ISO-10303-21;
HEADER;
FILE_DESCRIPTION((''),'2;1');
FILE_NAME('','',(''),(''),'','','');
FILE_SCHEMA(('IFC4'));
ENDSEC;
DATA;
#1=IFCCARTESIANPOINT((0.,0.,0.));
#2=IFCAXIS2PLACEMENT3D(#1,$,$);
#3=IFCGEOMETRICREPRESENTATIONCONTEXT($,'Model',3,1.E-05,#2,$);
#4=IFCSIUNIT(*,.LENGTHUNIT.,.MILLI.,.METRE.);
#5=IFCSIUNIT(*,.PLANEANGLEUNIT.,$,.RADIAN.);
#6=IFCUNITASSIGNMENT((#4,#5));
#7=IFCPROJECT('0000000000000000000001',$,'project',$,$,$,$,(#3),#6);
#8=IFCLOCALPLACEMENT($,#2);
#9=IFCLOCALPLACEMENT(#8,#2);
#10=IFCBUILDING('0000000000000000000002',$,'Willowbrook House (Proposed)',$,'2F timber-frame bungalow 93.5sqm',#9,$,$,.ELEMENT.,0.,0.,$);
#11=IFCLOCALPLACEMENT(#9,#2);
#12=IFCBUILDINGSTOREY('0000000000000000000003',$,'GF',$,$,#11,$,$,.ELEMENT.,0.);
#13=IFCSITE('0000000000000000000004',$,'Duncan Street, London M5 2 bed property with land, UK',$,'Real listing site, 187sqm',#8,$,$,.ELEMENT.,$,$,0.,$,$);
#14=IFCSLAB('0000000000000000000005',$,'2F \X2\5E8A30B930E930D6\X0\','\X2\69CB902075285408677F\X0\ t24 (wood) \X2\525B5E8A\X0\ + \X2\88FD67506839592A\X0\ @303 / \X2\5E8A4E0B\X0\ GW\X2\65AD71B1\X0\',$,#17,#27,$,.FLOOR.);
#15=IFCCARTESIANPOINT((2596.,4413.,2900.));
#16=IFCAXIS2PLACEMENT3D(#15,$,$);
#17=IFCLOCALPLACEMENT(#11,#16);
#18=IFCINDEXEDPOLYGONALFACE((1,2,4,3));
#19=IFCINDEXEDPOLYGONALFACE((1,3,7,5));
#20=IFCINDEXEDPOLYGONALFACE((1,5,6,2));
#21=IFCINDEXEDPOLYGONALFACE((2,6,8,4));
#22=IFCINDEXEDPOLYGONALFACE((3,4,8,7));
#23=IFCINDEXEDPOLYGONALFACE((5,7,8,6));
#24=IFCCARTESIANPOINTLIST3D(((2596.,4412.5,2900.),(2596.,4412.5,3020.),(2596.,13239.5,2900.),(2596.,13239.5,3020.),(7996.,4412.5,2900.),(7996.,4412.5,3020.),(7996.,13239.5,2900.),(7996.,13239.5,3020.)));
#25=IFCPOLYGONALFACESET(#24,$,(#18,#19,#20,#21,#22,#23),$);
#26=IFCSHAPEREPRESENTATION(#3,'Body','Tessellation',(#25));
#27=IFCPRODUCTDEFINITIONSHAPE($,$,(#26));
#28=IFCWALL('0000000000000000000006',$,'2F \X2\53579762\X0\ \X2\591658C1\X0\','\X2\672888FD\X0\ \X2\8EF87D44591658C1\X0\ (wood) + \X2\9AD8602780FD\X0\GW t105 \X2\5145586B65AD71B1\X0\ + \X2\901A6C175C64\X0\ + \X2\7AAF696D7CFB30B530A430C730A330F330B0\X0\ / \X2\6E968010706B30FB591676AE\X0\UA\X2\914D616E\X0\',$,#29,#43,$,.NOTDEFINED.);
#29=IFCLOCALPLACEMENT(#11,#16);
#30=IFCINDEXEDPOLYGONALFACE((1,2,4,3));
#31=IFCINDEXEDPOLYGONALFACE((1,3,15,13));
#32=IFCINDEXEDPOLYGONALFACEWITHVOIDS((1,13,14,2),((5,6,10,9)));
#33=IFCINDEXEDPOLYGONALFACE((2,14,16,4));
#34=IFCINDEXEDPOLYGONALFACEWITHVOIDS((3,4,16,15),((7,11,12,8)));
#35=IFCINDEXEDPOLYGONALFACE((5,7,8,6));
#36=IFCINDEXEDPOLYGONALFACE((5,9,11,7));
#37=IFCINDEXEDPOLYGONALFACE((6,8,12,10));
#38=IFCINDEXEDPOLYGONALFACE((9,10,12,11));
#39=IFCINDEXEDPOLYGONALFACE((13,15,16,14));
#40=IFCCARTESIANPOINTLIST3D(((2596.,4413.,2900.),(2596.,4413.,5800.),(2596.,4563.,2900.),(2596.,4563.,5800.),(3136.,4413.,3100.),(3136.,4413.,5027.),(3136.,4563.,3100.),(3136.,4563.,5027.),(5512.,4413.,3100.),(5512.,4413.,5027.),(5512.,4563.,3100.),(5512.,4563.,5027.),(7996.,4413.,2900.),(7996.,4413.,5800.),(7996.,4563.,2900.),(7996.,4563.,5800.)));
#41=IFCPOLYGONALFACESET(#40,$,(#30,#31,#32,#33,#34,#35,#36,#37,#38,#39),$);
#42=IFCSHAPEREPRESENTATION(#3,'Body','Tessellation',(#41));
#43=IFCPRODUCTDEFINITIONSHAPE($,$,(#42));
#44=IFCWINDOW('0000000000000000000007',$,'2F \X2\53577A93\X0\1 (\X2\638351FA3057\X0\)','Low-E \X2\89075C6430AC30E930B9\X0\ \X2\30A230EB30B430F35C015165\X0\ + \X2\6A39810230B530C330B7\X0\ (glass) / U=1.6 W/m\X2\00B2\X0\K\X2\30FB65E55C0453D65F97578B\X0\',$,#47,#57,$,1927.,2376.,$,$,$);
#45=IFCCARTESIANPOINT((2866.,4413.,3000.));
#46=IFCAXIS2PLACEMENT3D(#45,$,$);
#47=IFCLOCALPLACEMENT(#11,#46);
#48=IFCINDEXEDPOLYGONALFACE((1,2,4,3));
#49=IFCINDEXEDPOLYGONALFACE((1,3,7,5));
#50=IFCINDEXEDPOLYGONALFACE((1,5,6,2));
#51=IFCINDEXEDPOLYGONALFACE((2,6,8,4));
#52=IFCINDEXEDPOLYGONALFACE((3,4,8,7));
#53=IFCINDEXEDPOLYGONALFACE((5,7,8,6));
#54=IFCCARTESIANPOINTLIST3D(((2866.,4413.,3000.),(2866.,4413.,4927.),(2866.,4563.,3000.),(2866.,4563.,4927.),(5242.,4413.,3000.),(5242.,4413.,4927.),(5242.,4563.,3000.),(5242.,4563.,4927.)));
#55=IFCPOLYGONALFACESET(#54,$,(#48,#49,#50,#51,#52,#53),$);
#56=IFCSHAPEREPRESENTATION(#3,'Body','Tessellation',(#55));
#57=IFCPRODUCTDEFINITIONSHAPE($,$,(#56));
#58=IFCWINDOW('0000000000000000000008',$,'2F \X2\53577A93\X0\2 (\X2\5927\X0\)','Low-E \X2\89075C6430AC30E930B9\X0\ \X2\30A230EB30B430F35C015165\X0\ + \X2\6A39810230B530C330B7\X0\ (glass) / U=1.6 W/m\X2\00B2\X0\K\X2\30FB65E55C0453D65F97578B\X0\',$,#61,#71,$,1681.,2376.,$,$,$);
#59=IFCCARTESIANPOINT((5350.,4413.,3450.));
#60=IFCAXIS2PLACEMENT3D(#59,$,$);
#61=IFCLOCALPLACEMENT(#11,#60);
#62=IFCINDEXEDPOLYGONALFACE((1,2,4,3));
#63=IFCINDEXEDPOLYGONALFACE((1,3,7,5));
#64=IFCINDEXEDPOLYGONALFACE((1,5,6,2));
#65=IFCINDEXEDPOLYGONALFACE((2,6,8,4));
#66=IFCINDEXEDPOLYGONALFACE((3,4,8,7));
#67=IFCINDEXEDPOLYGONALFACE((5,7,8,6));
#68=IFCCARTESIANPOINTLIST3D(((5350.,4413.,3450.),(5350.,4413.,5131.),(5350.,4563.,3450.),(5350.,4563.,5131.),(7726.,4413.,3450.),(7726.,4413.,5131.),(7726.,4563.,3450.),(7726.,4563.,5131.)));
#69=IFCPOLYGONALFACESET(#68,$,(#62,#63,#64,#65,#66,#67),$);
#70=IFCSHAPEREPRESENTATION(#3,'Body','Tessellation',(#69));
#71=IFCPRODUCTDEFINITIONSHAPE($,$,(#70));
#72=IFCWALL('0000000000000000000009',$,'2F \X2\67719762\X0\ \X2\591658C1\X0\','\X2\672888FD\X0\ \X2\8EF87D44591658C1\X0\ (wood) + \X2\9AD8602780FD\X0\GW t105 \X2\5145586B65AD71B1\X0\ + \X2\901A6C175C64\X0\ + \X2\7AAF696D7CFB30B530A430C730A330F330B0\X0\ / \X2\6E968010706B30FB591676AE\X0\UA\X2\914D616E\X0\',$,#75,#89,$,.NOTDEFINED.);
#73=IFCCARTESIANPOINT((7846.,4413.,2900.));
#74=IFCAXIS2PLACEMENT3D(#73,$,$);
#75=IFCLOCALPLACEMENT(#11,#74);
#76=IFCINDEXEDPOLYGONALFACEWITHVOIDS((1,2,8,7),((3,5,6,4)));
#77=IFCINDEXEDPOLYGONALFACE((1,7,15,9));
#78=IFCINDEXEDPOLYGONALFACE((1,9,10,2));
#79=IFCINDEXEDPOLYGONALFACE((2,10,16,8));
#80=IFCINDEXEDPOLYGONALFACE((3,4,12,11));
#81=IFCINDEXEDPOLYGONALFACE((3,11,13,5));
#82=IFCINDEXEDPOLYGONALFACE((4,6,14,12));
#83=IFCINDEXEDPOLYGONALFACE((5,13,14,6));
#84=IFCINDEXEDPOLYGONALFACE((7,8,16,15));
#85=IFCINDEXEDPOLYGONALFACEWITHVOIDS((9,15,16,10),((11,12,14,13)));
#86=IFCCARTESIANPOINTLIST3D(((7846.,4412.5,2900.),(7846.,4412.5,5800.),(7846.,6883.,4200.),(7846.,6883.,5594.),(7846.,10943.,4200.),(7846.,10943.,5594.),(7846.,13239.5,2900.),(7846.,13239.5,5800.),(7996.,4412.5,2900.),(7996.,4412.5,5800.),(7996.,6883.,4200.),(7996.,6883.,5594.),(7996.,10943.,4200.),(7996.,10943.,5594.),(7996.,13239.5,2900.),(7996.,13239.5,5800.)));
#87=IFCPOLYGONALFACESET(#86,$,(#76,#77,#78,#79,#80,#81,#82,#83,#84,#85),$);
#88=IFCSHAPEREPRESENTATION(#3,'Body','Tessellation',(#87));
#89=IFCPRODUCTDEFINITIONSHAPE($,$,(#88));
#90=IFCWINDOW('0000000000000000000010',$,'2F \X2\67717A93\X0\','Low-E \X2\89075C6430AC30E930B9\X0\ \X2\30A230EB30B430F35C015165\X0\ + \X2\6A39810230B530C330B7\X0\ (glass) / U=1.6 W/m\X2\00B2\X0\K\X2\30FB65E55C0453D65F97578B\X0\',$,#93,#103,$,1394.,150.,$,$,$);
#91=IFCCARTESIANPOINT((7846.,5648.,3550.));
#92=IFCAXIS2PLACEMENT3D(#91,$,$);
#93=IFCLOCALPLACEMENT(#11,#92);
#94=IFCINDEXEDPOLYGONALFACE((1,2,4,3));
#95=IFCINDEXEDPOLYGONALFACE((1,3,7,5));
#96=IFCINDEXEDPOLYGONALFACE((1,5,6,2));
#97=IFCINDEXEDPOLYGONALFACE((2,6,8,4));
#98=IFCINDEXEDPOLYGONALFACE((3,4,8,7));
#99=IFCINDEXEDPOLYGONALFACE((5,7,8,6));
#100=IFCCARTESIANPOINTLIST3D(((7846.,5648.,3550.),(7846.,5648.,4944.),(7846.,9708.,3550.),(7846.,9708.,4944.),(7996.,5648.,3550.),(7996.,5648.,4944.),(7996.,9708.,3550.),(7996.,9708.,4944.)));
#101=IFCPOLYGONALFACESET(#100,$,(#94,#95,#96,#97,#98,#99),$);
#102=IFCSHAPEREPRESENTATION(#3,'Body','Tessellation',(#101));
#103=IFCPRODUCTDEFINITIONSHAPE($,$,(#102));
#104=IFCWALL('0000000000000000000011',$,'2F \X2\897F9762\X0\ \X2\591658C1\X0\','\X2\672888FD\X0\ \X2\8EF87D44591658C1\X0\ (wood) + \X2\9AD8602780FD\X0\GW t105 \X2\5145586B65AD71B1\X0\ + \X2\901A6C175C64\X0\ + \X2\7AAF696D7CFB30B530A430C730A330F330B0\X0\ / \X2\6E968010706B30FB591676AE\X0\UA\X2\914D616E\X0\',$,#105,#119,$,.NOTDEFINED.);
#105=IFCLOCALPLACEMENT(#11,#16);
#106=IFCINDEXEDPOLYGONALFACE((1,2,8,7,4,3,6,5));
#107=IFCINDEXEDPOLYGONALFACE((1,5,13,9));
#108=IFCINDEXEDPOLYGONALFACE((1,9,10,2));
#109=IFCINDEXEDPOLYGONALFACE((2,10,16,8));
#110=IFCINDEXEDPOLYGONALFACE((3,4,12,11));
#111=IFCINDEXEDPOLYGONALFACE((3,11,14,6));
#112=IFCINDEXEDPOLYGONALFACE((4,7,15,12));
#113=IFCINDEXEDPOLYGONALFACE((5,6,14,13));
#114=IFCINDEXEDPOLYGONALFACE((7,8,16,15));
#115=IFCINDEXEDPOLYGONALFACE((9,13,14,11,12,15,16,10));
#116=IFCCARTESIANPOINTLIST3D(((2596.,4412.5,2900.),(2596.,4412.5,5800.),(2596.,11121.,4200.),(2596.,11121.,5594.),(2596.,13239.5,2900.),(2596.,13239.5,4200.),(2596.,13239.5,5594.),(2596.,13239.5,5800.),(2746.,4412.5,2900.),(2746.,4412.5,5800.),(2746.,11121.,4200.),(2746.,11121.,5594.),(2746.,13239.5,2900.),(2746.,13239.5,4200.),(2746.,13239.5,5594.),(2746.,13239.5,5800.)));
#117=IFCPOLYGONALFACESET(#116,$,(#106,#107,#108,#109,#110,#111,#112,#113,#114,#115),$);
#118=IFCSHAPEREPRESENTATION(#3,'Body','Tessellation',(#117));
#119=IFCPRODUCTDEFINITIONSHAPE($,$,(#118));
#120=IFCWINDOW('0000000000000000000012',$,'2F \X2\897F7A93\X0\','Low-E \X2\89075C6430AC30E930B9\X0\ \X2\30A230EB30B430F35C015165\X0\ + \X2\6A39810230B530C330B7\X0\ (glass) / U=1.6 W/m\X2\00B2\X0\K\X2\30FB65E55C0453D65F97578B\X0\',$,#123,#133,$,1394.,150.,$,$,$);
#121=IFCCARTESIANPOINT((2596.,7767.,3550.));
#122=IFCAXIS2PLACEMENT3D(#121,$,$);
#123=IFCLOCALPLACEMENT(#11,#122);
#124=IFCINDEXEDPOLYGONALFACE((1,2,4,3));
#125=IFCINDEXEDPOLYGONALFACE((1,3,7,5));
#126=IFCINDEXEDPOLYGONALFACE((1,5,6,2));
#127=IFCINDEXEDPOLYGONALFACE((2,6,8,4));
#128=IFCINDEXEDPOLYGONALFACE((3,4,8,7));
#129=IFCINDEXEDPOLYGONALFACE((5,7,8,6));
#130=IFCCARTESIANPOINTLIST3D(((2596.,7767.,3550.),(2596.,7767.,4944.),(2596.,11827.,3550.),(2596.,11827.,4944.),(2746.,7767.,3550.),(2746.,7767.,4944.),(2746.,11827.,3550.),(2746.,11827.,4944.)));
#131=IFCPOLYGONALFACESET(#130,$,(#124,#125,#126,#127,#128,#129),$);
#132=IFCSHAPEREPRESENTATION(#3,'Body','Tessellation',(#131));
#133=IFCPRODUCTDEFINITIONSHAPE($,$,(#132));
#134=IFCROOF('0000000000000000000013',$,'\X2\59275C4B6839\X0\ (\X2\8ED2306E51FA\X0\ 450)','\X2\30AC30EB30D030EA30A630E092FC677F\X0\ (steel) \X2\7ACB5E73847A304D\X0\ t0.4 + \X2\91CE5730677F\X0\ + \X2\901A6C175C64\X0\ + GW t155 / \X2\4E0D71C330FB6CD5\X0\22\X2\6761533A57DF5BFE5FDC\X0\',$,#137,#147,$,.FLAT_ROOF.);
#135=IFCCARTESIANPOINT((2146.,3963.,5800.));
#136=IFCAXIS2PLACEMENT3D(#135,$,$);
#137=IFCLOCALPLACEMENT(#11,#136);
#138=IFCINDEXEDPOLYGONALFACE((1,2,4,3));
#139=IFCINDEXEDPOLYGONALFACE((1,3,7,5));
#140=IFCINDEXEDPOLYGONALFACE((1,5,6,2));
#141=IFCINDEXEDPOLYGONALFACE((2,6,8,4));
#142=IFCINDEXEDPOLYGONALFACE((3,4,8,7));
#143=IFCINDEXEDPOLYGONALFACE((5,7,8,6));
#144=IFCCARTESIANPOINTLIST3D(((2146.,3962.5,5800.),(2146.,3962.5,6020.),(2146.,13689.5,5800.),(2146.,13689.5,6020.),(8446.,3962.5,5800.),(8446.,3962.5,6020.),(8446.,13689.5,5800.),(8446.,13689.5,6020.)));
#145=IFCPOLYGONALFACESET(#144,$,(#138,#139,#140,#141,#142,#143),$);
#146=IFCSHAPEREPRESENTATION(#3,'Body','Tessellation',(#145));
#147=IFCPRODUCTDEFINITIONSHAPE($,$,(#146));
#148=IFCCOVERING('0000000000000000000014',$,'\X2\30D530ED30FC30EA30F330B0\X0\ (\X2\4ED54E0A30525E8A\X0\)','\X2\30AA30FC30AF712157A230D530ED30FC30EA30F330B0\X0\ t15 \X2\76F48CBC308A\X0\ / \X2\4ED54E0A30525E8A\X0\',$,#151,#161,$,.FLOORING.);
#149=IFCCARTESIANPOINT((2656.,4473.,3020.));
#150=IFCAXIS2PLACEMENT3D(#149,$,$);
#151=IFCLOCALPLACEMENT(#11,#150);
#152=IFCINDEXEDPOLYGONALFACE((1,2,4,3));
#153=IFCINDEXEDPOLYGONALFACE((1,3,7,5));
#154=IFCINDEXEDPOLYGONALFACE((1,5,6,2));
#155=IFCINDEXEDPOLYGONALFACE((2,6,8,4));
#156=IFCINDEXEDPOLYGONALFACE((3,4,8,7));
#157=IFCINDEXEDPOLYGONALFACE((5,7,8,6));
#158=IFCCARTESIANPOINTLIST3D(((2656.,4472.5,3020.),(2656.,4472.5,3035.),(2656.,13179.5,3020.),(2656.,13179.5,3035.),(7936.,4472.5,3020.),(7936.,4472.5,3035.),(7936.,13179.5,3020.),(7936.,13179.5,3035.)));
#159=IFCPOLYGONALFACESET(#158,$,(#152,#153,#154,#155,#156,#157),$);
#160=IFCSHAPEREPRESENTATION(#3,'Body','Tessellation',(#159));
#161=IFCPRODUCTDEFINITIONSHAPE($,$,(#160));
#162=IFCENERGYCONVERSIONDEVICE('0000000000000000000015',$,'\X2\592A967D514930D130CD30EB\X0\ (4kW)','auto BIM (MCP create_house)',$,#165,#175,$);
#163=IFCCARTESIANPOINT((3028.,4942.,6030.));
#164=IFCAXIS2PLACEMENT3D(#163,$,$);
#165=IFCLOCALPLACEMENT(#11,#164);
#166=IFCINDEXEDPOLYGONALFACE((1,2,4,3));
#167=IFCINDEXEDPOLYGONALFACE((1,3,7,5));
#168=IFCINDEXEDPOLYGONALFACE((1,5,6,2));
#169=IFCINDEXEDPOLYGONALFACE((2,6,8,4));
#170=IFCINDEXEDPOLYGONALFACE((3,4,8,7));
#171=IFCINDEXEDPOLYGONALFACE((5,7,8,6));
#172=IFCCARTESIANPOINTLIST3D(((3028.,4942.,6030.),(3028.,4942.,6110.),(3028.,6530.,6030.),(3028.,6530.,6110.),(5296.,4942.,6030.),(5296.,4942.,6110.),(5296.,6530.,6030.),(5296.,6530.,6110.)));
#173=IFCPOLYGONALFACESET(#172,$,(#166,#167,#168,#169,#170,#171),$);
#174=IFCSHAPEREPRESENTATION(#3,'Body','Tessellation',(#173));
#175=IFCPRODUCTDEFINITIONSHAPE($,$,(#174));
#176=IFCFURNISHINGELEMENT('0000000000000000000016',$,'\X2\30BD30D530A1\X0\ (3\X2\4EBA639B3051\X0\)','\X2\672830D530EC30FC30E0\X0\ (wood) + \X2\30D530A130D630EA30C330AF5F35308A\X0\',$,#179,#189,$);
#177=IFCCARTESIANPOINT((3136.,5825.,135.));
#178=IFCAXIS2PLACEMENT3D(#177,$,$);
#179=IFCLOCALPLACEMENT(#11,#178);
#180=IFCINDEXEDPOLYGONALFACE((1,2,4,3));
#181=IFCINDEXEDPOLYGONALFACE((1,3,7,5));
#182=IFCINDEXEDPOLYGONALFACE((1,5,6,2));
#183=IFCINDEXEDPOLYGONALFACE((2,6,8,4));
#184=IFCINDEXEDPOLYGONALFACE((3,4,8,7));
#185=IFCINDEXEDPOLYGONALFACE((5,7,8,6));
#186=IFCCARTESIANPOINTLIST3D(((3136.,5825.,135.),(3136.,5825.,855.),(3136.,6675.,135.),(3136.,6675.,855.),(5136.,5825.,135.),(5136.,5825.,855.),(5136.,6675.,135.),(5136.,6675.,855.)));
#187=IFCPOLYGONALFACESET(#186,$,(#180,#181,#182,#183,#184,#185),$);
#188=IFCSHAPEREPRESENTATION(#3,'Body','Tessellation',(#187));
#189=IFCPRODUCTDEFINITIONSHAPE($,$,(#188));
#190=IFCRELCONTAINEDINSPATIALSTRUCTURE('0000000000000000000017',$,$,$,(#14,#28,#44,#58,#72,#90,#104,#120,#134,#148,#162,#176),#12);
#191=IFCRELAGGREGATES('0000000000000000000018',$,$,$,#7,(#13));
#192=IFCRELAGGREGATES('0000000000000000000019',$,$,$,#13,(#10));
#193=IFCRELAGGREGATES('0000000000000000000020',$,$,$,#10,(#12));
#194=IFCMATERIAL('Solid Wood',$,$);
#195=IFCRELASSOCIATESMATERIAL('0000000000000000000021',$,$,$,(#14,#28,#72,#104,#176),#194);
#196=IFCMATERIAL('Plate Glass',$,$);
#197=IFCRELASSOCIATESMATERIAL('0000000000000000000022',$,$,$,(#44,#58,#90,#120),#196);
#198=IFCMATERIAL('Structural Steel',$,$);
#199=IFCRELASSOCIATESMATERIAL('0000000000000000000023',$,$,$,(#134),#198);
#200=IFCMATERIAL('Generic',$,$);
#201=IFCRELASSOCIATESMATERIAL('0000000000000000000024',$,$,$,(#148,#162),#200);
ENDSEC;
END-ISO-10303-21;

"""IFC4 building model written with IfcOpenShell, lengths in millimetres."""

from ifc_helpers import new_model, si_unit, frame, frame_2d, origin, place, context, project, spatial, rectangle, extrude, material, element, fill, save


model = new_model("IFC4")

# Units and contexts
model_context = context("Model", 3, precision=1e-05, world=origin())
ifc_project = project(units=[si_unit("LENGTHUNIT", "METRE", prefix="MILLI"), si_unit("PLANEANGLEUNIT", "RADIAN")], contexts=[model_context])

# Site, building, storey
site_placement = place(None, origin())
site = spatial("IfcSite", under=ifc_project, at=site_placement, Name="Duncan Street, London M5 2 bed property with land, UK", ObjectType="Real listing site, 187sqm", CompositionType="ELEMENT", RefElevation=0.0)
building_placement = place(site_placement, origin())
building = spatial("IfcBuilding", under=site, at=building_placement, Name="Willowbrook House (Proposed)", ObjectType="2F timber-frame bungalow 93.5sqm", CompositionType="ELEMENT", ElevationOfRefHeight=0.0, ElevationOfTerrain=0.0)
storey_placement = place(building_placement, origin())
storey = spatial("IfcBuildingStorey", under=building, at=storey_placement, Name="GF", CompositionType="ELEMENT", Elevation=0.0)

# Slab
ifc_material_1 = material(Name="Solid Wood")
slab_placement = place(storey_placement, frame((2596.0, 4413.0, 2900.0)))
element("IfcSlab", 1, at=slab_placement, inside=storey, material=ifc_material_1, Name="2F 床スラブ", Description="構造用合板 t24 (wood) 剛床 + 製材根太 @303 / 床下 GW断熱", PredefinedType="FLOOR", context=model_context, shape_type="SweptSolid", body=[
    extrude(rectangle(XDim=5400.0, YDim=8827.0, at=frame_2d((2700.0, 4413.0))), frame((2596.0, 4413.0, 2900.0)), (0.0, 0.0, 1.0), 120.0),
])

# Wall, openings, windows
wall_1_placement = place(storey_placement, frame((2596.0, 4413.0, 2900.0)))
wall_1 = element("IfcWall", 2, at=wall_1_placement, inside=storey, material=ifc_material_1, Name="2F 南面 外壁", Description="木製 軸組外壁 (wood) + 高性能GW t105 充填断熱 + 通気層 + 窯業系サイディング / 準耐火・外皮UA配慮", PredefinedType="NOTDEFINED", context=model_context, shape_type="SweptSolid", body=[
    extrude(rectangle(XDim=5400.0, YDim=150.0, at=frame_2d((2700.0, 75.0))), frame((2596.0, 4413.0, 2900.0)), (0.0, 0.0, 1.0), 2900.0),
])
opening_1_placement = place(storey_placement, frame((2866.0, 4413.0, 3000.0)))
opening_1 = element("IfcOpeningElement", 3, at=opening_1_placement, cuts=wall_1, PredefinedType="NOTDEFINED", context=model_context, shape_type="SweptSolid", body=[
    extrude(rectangle(XDim=2376.0, YDim=150.0, at=frame_2d((1188.0, 75.0))), frame((2866.0, 4413.0, 3000.0)), (0.0, 0.0, 1.0), 1927.0),
])
opening_2_placement = place(storey_placement, frame((5350.0, 4413.0, 3450.0)))
opening_2 = element("IfcOpeningElement", 4, at=opening_2_placement, cuts=wall_1, PredefinedType="NOTDEFINED", context=model_context, shape_type="SweptSolid", body=[
    extrude(rectangle(XDim=2376.0, YDim=150.0, at=frame_2d((1188.0, 75.0))), frame((5350.0, 4413.0, 3450.0)), (0.0, 0.0, 1.0), 1681.0),
])
ifc_material_2 = material(Name="Plate Glass")
window_1_placement = place(storey_placement, frame((2866.0, 4413.0, 3000.0)))
window_1 = element("IfcWindow", 5, at=window_1_placement, inside=storey, material=ifc_material_2, Name="2F 南窓1 (掃出し)", Description="Low-E 複層ガラス アルゴン封入 + 樹脂サッシ (glass) / U=1.6 W/m²K・日射取得型", OverallHeight=1927.0, OverallWidth=2376.0, context=model_context, shape_type="SweptSolid", body=[
    extrude(rectangle(XDim=2376.0, YDim=150.0, at=frame_2d((1188.0, 75.0))), frame((2866.0, 4413.0, 3000.0)), (0.0, 0.0, 1.0), 1927.0),
])
fill(opening_1, window_1)
window_2_placement = place(storey_placement, frame((5350.0, 4413.0, 3450.0)))
window_2 = element("IfcWindow", 6, at=window_2_placement, inside=storey, material=ifc_material_2, Name="2F 南窓2 (大)", Description="Low-E 複層ガラス アルゴン封入 + 樹脂サッシ (glass) / U=1.6 W/m²K・日射取得型", OverallHeight=1681.0, OverallWidth=2376.0, context=model_context, shape_type="SweptSolid", body=[
    extrude(rectangle(XDim=2376.0, YDim=150.0, at=frame_2d((1188.0, 75.0))), frame((5350.0, 4413.0, 3450.0)), (0.0, 0.0, 1.0), 1681.0),
])
fill(opening_2, window_2)

# Walls, openings, windows
wall_2_placement = place(storey_placement, frame((7846.0, 4413.0, 2900.0)))
wall_2 = element("IfcWall", 7, at=wall_2_placement, inside=storey, material=ifc_material_1, Name="2F 東面 外壁", Description="木製 軸組外壁 (wood) + 高性能GW t105 充填断熱 + 通気層 + 窯業系サイディング / 準耐火・外皮UA配慮", PredefinedType="NOTDEFINED", context=model_context, shape_type="SweptSolid", body=[
    extrude(rectangle(XDim=150.0, YDim=8827.0, at=frame_2d((75.0, 4413.0))), frame((7846.0, 4413.0, 2900.0)), (0.0, 0.0, 1.0), 2900.0),
])
opening_3_placement = place(storey_placement, frame((7846.0, 5648.0, 3550.0)))
opening_3 = element("IfcOpeningElement", 8, at=opening_3_placement, cuts=wall_2, PredefinedType="NOTDEFINED", context=model_context, shape_type="SweptSolid", body=[
    extrude(rectangle(XDim=150.0, YDim=4060.0, at=frame_2d((75.0, 2030.0))), frame((7846.0, 5648.0, 3550.0)), (0.0, 0.0, 1.0), 1394.0),
])
window_3_placement = place(storey_placement, frame((7846.0, 5648.0, 3550.0)))
window_3 = element("IfcWindow", 9, at=window_3_placement, inside=storey, material=ifc_material_2, Name="2F 東窓", Description="Low-E 複層ガラス アルゴン封入 + 樹脂サッシ (glass) / U=1.6 W/m²K・日射取得型", OverallHeight=1394.0, OverallWidth=150.0, context=model_context, shape_type="SweptSolid", body=[
    extrude(rectangle(XDim=150.0, YDim=4060.0, at=frame_2d((75.0, 2030.0))), frame((7846.0, 5648.0, 3550.0)), (0.0, 0.0, 1.0), 1394.0),
])
fill(opening_3, window_3)
wall_3_placement = place(storey_placement, frame((2596.0, 4413.0, 2900.0)))
wall_3 = element("IfcWall", 10, at=wall_3_placement, inside=storey, material=ifc_material_1, Name="2F 西面 外壁", Description="木製 軸組外壁 (wood) + 高性能GW t105 充填断熱 + 通気層 + 窯業系サイディング / 準耐火・外皮UA配慮", PredefinedType="NOTDEFINED", context=model_context, shape_type="SweptSolid", body=[
    extrude(rectangle(XDim=150.0, YDim=8827.0, at=frame_2d((75.0, 4413.0))), frame((2596.0, 4413.0, 2900.0)), (0.0, 0.0, 1.0), 2900.0),
])
opening_4_placement = place(storey_placement, frame((2596.0, 7767.0, 3550.0)))
opening_4 = element("IfcOpeningElement", 11, at=opening_4_placement, cuts=wall_3, PredefinedType="NOTDEFINED", context=model_context, shape_type="SweptSolid", body=[
    extrude(rectangle(XDim=150.0, YDim=4060.0, at=frame_2d((75.0, 2030.0))), frame((2596.0, 7767.0, 3550.0)), (0.0, 0.0, 1.0), 1394.0),
])
window_4_placement = place(storey_placement, frame((2596.0, 7767.0, 3550.0)))
window_4 = element("IfcWindow", 12, at=window_4_placement, inside=storey, material=ifc_material_2, Name="2F 西窓", Description="Low-E 複層ガラス アルゴン封入 + 樹脂サッシ (glass) / U=1.6 W/m²K・日射取得型", OverallHeight=1394.0, OverallWidth=150.0, context=model_context, shape_type="SweptSolid", body=[
    extrude(rectangle(XDim=150.0, YDim=4060.0, at=frame_2d((75.0, 2030.0))), frame((2596.0, 7767.0, 3550.0)), (0.0, 0.0, 1.0), 1394.0),
])
fill(opening_4, window_4)

# Roof
ifc_material_3 = material(Name="Structural Steel")
roof_placement = place(storey_placement, frame((2146.0, 3963.0, 5800.0)))
element("IfcRoof", 13, at=roof_placement, inside=storey, material=ifc_material_3, Name="大屋根 (軒の出 450)", Description="ガルバリウム鋼板 (steel) 立平葺き t0.4 + 野地板 + 通気層 + GW t155 / 不燃・法22条区域対応", PredefinedType="FLAT_ROOF", context=model_context, shape_type="SweptSolid", body=[
    extrude(rectangle(XDim=6300.0, YDim=9727.0, at=frame_2d((3150.0, 4863.0))), frame((2146.0, 3963.0, 5800.0)), (0.0, 0.0, 1.0), 220.0),
])

# Covering
ifc_material_4 = material(Name="Generic")
covering_placement = place(storey_placement, frame((2656.0, 4473.0, 3020.0)))
element("IfcCovering", 14, at=covering_placement, inside=storey, material=ifc_material_4, Name="フローリング (仕上げ床)", Description="オーク無垢フローリング t15 直貼り / 仕上げ床", PredefinedType="FLOORING", context=model_context, shape_type="SweptSolid", body=[
    extrude(rectangle(XDim=5280.0, YDim=8707.0, at=frame_2d((2640.0, 4353.0))), frame((2656.0, 4473.0, 3020.0)), (0.0, 0.0, 1.0), 15.0),
])

# Energy conversion device
energy_conversion_device_placement = place(storey_placement, frame((3028.0, 4942.0, 6030.0)))
element("IfcEnergyConversionDevice", 15, at=energy_conversion_device_placement, inside=storey, material=ifc_material_4, Name="太陽光パネル (4kW)", Description="auto BIM (MCP create_house)", context=model_context, shape_type="SweptSolid", body=[
    extrude(rectangle(XDim=2268.0, YDim=1588.0, at=frame_2d((1134.0, 794.0))), frame((3028.0, 4942.0, 6030.0)), (0.0, 0.0, 1.0), 80.0),
])

# Furnishing element
furnishing_1_placement = place(storey_placement, frame((3136.0, 5825.0, 135.0)))
element("IfcFurnishingElement", 16, at=furnishing_1_placement, inside=storey, material=ifc_material_1, Name="ソファ (3人掛け)", Description="木フレーム (wood) + ファブリック張り", context=model_context, shape_type="SweptSolid", body=[
    extrude(rectangle(XDim=2000.0, YDim=850.0, at=frame_2d((1000.0, 425.0))), frame((3136.0, 5825.0, 135.0)), (0.0, 0.0, 1.0), 720.0),
])

save(model, "model.ifc")
